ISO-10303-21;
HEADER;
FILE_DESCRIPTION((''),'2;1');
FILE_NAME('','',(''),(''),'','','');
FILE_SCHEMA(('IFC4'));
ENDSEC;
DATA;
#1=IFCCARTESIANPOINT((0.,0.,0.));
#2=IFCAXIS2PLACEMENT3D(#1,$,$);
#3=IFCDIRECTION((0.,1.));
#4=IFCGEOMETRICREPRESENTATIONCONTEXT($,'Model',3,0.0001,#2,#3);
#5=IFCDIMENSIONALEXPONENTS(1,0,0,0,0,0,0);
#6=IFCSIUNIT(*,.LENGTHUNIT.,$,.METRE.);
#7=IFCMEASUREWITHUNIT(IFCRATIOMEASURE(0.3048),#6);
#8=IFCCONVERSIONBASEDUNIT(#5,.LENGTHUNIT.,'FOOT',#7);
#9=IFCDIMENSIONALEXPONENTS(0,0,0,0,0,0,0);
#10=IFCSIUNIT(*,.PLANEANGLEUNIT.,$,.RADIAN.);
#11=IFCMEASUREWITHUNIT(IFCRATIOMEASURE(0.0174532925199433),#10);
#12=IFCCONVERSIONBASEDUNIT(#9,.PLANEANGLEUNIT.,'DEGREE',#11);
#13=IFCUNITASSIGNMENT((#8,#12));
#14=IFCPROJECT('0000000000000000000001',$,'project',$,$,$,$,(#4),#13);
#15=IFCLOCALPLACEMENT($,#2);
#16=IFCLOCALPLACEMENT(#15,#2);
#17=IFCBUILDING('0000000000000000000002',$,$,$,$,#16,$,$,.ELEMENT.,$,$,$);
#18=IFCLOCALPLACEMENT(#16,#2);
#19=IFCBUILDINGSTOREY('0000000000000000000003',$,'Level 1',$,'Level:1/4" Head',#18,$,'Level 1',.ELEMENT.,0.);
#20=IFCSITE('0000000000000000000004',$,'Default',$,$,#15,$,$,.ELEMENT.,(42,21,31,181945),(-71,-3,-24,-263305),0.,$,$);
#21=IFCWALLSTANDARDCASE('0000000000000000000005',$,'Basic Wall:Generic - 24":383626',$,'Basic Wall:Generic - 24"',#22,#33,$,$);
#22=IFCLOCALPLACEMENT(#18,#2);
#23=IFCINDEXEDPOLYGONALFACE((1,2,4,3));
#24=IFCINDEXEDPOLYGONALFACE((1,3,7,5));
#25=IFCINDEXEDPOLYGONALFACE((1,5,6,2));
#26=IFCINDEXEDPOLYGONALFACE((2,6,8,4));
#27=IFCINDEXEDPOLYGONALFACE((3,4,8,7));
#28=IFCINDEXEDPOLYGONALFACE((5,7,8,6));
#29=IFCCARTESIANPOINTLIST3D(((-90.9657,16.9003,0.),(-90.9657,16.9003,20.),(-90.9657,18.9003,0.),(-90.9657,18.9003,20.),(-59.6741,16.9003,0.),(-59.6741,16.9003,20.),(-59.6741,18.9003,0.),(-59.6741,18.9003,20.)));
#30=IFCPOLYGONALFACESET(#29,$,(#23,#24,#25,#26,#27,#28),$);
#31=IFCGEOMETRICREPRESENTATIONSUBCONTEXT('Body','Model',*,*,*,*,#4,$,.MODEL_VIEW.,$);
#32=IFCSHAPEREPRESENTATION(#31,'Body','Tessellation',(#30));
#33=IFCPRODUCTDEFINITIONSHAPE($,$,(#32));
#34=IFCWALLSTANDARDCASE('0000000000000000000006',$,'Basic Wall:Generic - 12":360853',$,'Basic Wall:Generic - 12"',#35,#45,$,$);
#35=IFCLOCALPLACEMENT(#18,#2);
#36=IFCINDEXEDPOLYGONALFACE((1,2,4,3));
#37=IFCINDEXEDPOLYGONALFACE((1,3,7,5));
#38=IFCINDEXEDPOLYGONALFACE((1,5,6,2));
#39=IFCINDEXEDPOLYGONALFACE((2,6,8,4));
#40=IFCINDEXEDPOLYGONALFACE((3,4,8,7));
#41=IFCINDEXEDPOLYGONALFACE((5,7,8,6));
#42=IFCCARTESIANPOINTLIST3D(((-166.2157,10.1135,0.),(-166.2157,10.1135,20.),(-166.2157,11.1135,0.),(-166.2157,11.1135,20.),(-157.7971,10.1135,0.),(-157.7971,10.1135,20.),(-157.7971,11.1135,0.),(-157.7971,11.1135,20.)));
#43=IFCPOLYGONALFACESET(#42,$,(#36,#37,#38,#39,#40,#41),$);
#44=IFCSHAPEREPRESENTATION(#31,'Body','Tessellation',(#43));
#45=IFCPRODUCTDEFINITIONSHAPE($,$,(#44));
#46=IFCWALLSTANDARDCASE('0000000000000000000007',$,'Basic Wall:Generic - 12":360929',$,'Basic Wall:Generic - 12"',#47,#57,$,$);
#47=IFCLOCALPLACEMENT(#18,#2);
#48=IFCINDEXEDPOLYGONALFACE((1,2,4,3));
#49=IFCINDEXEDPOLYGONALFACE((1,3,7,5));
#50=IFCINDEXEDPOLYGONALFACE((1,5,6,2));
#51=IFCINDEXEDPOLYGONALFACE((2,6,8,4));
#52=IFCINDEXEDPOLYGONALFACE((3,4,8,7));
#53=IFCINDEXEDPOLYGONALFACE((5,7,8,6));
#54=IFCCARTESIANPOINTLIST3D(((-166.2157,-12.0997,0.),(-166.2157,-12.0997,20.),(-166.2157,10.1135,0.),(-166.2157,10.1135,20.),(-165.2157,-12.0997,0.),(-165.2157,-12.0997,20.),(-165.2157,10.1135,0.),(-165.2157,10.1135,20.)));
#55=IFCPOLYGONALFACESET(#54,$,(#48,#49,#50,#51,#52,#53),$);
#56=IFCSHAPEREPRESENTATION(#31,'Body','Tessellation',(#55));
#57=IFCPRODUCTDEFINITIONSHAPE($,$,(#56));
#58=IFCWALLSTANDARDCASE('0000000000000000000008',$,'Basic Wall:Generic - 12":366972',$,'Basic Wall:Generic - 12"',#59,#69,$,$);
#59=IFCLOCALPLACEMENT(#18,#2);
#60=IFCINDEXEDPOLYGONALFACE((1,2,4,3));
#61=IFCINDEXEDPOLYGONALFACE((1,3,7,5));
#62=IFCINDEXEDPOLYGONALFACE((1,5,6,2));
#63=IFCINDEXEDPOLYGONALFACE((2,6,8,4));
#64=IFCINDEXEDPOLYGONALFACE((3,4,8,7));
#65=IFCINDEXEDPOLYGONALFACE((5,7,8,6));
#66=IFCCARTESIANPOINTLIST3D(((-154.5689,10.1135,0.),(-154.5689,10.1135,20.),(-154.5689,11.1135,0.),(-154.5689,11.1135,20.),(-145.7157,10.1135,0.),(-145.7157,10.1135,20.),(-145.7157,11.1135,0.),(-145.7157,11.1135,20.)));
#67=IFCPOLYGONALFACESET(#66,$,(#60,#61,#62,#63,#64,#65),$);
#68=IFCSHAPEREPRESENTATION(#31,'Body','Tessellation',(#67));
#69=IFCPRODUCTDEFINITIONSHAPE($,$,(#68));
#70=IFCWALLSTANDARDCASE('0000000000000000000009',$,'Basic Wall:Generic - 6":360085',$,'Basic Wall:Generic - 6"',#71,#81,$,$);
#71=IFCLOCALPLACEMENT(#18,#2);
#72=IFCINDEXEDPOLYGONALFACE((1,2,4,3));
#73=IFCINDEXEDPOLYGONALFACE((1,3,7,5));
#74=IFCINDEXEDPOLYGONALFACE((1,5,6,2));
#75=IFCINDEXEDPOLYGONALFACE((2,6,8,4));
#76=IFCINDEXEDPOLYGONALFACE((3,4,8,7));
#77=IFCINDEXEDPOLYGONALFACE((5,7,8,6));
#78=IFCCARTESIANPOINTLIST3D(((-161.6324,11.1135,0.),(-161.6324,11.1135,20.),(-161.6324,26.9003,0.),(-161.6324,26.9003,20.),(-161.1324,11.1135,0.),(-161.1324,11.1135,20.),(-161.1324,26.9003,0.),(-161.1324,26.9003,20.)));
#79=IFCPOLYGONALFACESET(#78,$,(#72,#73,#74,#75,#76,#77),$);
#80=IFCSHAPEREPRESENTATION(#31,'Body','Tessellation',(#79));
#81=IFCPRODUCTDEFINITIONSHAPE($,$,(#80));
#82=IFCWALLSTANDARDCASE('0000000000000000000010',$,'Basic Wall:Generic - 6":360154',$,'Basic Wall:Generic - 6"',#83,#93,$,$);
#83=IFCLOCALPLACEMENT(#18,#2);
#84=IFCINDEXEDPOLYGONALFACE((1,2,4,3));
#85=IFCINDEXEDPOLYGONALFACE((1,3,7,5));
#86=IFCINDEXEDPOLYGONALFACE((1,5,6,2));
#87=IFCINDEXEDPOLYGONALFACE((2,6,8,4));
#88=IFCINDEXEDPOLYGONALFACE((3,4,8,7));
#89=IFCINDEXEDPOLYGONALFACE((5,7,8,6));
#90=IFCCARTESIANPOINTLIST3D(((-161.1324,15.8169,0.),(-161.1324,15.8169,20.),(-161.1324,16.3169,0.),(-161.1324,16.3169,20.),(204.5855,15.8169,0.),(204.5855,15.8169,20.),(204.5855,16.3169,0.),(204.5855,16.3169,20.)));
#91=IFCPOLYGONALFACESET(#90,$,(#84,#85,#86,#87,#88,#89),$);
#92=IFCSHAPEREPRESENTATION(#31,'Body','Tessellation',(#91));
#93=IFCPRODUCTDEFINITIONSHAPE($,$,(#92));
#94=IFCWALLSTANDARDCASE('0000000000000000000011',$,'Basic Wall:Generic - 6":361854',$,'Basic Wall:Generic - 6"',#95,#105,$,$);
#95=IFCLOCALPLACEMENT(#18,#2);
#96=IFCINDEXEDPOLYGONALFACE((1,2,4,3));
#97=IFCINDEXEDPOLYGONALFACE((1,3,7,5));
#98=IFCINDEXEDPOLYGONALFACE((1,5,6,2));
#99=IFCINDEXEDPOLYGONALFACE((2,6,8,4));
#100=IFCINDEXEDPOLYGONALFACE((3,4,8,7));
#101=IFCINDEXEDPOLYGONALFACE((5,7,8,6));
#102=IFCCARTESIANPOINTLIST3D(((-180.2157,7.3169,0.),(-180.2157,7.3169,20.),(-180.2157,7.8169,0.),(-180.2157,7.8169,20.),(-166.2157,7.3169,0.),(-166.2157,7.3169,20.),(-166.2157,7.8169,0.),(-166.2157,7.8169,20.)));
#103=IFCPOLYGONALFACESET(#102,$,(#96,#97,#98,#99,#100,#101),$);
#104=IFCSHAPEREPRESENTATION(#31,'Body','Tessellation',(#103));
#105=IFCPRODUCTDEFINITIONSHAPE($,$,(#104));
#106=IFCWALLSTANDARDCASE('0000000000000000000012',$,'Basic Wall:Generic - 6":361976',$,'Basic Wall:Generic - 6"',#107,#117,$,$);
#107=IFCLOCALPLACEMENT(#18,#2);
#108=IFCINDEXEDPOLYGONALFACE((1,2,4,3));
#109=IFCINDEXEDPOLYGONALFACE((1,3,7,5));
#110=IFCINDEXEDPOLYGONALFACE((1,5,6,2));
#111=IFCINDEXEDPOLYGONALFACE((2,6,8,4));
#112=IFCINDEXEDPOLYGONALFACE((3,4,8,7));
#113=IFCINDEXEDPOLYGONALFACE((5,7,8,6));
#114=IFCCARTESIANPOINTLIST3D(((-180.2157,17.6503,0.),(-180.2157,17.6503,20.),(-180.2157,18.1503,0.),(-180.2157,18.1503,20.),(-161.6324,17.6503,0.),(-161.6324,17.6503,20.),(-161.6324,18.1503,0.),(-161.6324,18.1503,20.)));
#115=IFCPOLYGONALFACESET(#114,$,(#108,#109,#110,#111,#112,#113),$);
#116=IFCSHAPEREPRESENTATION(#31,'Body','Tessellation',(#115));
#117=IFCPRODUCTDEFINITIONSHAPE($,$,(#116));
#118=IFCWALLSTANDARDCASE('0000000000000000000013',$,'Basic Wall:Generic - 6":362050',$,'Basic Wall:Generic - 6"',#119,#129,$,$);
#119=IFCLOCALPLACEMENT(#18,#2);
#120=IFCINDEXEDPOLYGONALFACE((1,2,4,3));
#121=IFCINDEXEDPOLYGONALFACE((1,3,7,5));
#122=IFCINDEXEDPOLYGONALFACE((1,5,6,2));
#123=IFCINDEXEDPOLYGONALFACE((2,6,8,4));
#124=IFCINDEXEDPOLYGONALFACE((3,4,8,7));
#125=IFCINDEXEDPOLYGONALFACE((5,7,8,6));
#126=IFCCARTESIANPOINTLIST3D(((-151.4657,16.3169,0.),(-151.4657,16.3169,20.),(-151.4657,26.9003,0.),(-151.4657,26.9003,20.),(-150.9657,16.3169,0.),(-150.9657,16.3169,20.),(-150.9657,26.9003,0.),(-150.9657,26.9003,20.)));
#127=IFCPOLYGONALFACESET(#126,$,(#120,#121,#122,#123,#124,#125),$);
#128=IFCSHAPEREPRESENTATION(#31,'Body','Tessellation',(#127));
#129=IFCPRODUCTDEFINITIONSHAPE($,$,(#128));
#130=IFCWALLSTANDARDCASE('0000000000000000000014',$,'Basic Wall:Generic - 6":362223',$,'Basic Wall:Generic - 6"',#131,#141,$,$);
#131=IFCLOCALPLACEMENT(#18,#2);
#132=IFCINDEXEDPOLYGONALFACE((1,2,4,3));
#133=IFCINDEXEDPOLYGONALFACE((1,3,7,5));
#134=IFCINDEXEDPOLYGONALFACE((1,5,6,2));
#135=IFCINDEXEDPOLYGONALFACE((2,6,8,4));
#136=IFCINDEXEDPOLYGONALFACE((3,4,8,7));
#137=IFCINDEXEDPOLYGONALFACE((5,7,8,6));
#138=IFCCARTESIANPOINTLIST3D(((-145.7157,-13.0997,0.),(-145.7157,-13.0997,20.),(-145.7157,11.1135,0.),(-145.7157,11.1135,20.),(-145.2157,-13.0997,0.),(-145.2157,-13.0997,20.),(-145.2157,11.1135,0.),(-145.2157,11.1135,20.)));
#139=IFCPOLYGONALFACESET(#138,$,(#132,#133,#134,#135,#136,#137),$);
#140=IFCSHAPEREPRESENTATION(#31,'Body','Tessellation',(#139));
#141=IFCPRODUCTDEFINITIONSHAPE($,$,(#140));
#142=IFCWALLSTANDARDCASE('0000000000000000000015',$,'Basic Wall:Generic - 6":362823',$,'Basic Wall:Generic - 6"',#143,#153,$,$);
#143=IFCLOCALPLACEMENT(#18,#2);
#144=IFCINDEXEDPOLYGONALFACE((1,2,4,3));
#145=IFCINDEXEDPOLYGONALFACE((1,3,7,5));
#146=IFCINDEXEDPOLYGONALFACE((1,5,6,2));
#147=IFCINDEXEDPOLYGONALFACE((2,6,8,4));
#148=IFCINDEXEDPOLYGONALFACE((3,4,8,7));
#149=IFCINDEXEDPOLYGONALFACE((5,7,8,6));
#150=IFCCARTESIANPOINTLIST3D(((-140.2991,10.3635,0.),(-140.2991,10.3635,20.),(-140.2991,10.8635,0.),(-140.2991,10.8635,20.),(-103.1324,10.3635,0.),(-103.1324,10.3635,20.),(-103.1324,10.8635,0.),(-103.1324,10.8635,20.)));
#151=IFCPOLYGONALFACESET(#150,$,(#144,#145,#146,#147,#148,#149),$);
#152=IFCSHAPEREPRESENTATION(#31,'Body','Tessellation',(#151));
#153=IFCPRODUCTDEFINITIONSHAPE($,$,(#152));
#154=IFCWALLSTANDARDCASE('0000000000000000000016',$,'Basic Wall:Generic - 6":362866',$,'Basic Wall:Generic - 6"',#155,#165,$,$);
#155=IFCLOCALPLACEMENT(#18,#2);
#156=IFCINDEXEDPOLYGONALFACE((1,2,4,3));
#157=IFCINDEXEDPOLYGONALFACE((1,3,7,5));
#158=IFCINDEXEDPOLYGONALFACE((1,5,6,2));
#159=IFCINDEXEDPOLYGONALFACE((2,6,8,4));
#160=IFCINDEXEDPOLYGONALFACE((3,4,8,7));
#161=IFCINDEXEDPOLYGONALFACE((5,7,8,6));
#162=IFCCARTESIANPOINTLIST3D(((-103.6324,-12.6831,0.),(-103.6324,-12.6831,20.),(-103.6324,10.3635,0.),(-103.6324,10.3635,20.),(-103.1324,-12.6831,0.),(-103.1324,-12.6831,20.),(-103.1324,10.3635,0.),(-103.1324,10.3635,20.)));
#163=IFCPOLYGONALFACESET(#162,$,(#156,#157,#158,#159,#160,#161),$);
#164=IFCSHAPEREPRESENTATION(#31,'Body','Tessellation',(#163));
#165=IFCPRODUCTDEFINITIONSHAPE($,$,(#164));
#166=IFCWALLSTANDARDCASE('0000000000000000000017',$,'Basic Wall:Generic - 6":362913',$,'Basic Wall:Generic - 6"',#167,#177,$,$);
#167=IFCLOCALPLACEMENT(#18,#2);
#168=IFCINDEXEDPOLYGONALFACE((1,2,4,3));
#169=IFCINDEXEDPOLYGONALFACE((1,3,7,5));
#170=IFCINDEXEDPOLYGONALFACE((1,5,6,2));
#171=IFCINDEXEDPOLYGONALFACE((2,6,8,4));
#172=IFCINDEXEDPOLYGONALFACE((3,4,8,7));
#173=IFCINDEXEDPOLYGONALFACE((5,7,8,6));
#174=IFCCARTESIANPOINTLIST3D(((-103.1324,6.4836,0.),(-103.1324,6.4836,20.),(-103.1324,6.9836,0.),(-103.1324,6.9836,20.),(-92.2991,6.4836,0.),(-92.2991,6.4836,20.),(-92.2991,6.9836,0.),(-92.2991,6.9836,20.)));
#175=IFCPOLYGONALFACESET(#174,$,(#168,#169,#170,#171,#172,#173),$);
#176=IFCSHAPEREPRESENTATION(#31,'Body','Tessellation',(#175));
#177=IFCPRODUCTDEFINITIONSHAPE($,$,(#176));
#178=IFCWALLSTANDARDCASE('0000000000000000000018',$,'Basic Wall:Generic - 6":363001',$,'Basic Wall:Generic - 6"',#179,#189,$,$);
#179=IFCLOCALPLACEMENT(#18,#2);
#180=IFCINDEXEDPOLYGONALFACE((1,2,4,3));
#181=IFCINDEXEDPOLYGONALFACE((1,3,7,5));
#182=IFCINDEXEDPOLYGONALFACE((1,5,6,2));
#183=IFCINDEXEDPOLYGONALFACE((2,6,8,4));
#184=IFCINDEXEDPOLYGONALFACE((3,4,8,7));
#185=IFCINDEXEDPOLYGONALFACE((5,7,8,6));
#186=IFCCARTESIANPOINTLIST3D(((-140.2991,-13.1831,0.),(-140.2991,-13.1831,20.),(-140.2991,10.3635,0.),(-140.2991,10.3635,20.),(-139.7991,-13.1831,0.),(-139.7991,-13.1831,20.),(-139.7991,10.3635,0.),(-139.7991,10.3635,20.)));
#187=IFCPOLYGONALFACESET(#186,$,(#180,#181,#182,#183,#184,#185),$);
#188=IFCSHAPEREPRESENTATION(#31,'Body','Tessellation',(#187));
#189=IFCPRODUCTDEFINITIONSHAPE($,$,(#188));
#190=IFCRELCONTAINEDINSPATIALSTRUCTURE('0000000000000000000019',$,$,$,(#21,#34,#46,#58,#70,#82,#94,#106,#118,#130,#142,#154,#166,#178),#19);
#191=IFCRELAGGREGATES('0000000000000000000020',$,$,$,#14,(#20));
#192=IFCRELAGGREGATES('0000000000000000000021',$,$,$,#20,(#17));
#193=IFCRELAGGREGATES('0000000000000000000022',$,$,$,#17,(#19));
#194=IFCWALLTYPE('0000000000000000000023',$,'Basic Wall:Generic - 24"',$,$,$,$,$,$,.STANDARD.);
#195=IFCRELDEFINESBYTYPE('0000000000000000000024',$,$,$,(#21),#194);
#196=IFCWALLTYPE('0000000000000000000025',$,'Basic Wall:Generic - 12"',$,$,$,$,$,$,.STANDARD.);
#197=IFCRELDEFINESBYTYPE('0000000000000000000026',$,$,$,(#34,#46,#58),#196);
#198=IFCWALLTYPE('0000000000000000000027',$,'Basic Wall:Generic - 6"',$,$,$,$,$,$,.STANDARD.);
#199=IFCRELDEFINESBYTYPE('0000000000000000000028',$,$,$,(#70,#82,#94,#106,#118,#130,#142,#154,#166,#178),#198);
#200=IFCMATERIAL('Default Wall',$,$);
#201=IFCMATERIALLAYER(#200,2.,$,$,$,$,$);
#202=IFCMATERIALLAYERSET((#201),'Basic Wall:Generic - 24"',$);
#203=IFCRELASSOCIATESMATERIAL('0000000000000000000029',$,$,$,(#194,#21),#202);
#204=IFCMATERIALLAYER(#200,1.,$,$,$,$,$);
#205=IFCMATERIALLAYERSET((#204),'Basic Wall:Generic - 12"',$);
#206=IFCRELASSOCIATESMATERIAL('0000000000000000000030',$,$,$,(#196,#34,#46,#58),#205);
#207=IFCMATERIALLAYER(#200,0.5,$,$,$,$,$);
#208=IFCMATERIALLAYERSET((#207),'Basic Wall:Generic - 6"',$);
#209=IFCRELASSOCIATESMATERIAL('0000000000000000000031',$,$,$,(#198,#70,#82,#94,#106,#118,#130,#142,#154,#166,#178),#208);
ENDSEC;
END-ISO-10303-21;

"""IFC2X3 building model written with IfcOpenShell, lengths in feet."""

from ifc_helpers import new_model, entity, si_unit, converted_unit, direction, frame, frame_2d, origin, place, context, subcontext, project, spatial, rectangle, extrude, material, layer, layer_set, layer_usage, type_object, element, save


model = new_model("IFC2X3")

# Units and contexts
model_context = context("Model", 3, precision=0.0001, world=origin(), true_north=direction((0.0, 1.0)))
body_context = subcontext(model_context, "Body", "Model", "MODEL_VIEW")
ifc_project = project(units=[converted_unit("LENGTHUNIT", "FOOT", entity("IfcRatioMeasure", 0.3048), si_unit("LENGTHUNIT", "METRE"), dimensions=[1, 0, 0, 0, 0, 0, 0]), converted_unit("PLANEANGLEUNIT", "DEGREE", entity("IfcRatioMeasure", 0.0174532925199433), si_unit("PLANEANGLEUNIT", "RADIAN"), dimensions=[0, 0, 0, 0, 0, 0, 0])], contexts=[model_context])

# Site, building, storey
site_placement = place(None, origin())
site = spatial("IfcSite", under=ifc_project, at=site_placement, Name="Default", CompositionType="ELEMENT", RefLatitude=(42, 21, 31, 181945), RefLongitude=(-71, -3, -24, -263305), RefElevation=0.0)
building_placement = place(site_placement, origin())
building = spatial("IfcBuilding", under=site, at=building_placement, CompositionType="ELEMENT")
storey_placement = place(building_placement, origin())
storey = spatial("IfcBuildingStorey", under=building, at=storey_placement, Name="Level 1", ObjectType="Level:1/4\" Head", LongName="Level 1", CompositionType="ELEMENT", Elevation=0.0)

# Walls
ifc_material = material(Name="Default Wall")
ifc_layer_1 = layer(ifc_material, 2.0)
ifc_layer_set_1 = layer_set([ifc_layer_1], Name="Basic Wall:Generic - 24\"")
ifc_layer_usage_1 = layer_usage(ifc_layer_set_1, "AXIS2", "NEGATIVE", 1.0)
wall_type_1 = type_object("IfcWallType", Name="Basic Wall:Generic - 24\"", PredefinedType="STANDARD", material=ifc_layer_set_1)
wall_1_placement = place(storey_placement, frame((-90.9657, 17.9003, 0.0)))
element("IfcWallStandardCase", 1, at=wall_1_placement, inside=storey, type_object=wall_type_1, material=ifc_layer_usage_1, Name="Basic Wall:Generic - 24\":383626", ObjectType="Basic Wall:Generic - 24\"", context=body_context, shape_type="SweptSolid", body=[
    extrude(rectangle(XDim=31.2917, YDim=2.0, at=frame_2d((15.6458, 0.0), x_axis=(-1.0, 0.0))), origin(), (0.0, 0.0, 1.0), 20.0),
])
ifc_layer_2 = layer(ifc_material, 1.0)
ifc_layer_set_2 = layer_set([ifc_layer_2], Name="Basic Wall:Generic - 12\"")
ifc_layer_usage_2 = layer_usage(ifc_layer_set_2, "AXIS2", "NEGATIVE", 0.5)
wall_type_2 = type_object("IfcWallType", Name="Basic Wall:Generic - 12\"", PredefinedType="STANDARD", material=ifc_layer_set_2)
wall_2_placement = place(storey_placement, frame((-157.7971, 10.6135, 0.0), z_axis=(0.0, 0.0, 1.0), x_axis=(-1.0, 0.0, 0.0)))
element("IfcWallStandardCase", 2, at=wall_2_placement, inside=storey, type_object=wall_type_2, material=ifc_layer_usage_2, Name="Basic Wall:Generic - 12\":360853", ObjectType="Basic Wall:Generic - 12\"", context=body_context, shape_type="SweptSolid", body=[
    extrude(rectangle(XDim=8.4186, YDim=1.0, at=frame_2d((4.2093, 0.0), x_axis=(-1.0, 0.0))), origin(), (0.0, 0.0, 1.0), 20.0),
])
ifc_layer_usage_3 = layer_usage(ifc_layer_set_2, "AXIS2", "NEGATIVE", 0.5)
wall_3_placement = place(storey_placement, frame((-165.7157, 10.1135, 0.0), z_axis=(0.0, 0.0, 1.0), x_axis=(0.0, -1.0, 0.0)))
element("IfcWallStandardCase", 3, at=wall_3_placement, inside=storey, type_object=wall_type_2, material=ifc_layer_usage_3, Name="Basic Wall:Generic - 12\":360929", ObjectType="Basic Wall:Generic - 12\"", context=body_context, shape_type="SweptSolid", body=[
    extrude(rectangle(XDim=22.2133, YDim=1.0, at=frame_2d((11.1066, 0.0), x_axis=(-1.0, 0.0))), origin(), (0.0, 0.0, 1.0), 20.0),
])
ifc_layer_usage_4 = layer_usage(ifc_layer_set_2, "AXIS2", "NEGATIVE", 0.5)
wall_4_placement = place(storey_placement, frame((-154.5689, 10.6135, 0.0)))
element("IfcWallStandardCase", 4, at=wall_4_placement, inside=storey, type_object=wall_type_2, material=ifc_layer_usage_4, Name="Basic Wall:Generic - 12\":366972", ObjectType="Basic Wall:Generic - 12\"", context=body_context, shape_type="SweptSolid", body=[
    extrude(rectangle(XDim=8.8532, YDim=1.0, at=frame_2d((4.4266, 0.0), x_axis=(-1.0, 0.0))), origin(), (0.0, 0.0, 1.0), 20.0),
])
ifc_layer_3 = layer(ifc_material, 0.5)
ifc_layer_set_3 = layer_set([ifc_layer_3], Name="Basic Wall:Generic - 6\"")
ifc_layer_usage_5 = layer_usage(ifc_layer_set_3, "AXIS2", "NEGATIVE", 0.25)
wall_type_3 = type_object("IfcWallType", Name="Basic Wall:Generic - 6\"", PredefinedType="STANDARD", material=ifc_layer_set_3)
wall_5_placement = place(storey_placement, frame((-161.3824, 26.9003, 0.0), z_axis=(0.0, 0.0, 1.0), x_axis=(0.0, -1.0, 0.0)))
element("IfcWallStandardCase", 5, at=wall_5_placement, inside=storey, type_object=wall_type_3, material=ifc_layer_usage_5, Name="Basic Wall:Generic - 6\":360085", ObjectType="Basic Wall:Generic - 6\"", context=body_context, shape_type="SweptSolid", body=[
    extrude(rectangle(XDim=15.7867, YDim=0.5, at=frame_2d((7.8934, 0.0), x_axis=(-1.0, 0.0))), origin(), (0.0, 0.0, 1.0), 20.0),
])
ifc_layer_usage_6 = layer_usage(ifc_layer_set_3, "AXIS2", "NEGATIVE", 0.25)
wall_6_placement = place(storey_placement, frame((-161.1324, 16.0669, 0.0)))
element("IfcWallStandardCase", 6, at=wall_6_placement, inside=storey, type_object=wall_type_3, material=ifc_layer_usage_6, Name="Basic Wall:Generic - 6\":360154", ObjectType="Basic Wall:Generic - 6\"", context=body_context, shape_type="SweptSolid", body=[
    extrude(rectangle(XDim=365.7179, YDim=0.5, at=frame_2d((182.859, 0.0), x_axis=(-1.0, 0.0))), origin(), (0.0, 0.0, 1.0), 20.0),
])
ifc_layer_usage_7 = layer_usage(ifc_layer_set_3, "AXIS2", "NEGATIVE", 0.25)
wall_7_placement = place(storey_placement, frame((-180.2157, 7.5669, 0.0)))
element("IfcWallStandardCase", 7, at=wall_7_placement, inside=storey, type_object=wall_type_3, material=ifc_layer_usage_7, Name="Basic Wall:Generic - 6\":361854", ObjectType="Basic Wall:Generic - 6\"", context=body_context, shape_type="SweptSolid", body=[
    extrude(rectangle(XDim=14.0, YDim=0.5, at=frame_2d((7.0, 0.0), x_axis=(-1.0, 0.0))), origin(), (0.0, 0.0, 1.0), 20.0),
])
ifc_layer_usage_8 = layer_usage(ifc_layer_set_3, "AXIS2", "NEGATIVE", 0.25)
wall_8_placement = place(storey_placement, frame((-180.2157, 17.9003, 0.0)))
element("IfcWallStandardCase", 8, at=wall_8_placement, inside=storey, type_object=wall_type_3, material=ifc_layer_usage_8, Name="Basic Wall:Generic - 6\":361976", ObjectType="Basic Wall:Generic - 6\"", context=body_context, shape_type="SweptSolid", body=[
    extrude(rectangle(XDim=18.5833, YDim=0.5, at=frame_2d((9.2917, 0.0), x_axis=(-1.0, 0.0))), origin(), (0.0, 0.0, 1.0), 20.0),
])
ifc_layer_usage_9 = layer_usage(ifc_layer_set_3, "AXIS2", "NEGATIVE", 0.25)
wall_9_placement = place(storey_placement, frame((-151.2157, 26.9003, 0.0), z_axis=(0.0, 0.0, 1.0), x_axis=(0.0, -1.0, 0.0)))
element("IfcWallStandardCase", 9, at=wall_9_placement, inside=storey, type_object=wall_type_3, material=ifc_layer_usage_9, Name="Basic Wall:Generic - 6\":362050", ObjectType="Basic Wall:Generic - 6\"", context=body_context, shape_type="SweptSolid", body=[
    extrude(rectangle(XDim=10.5833, YDim=0.5, at=frame_2d((5.2917, 0.0), x_axis=(-1.0, 0.0))), origin(), (0.0, 0.0, 1.0), 20.0),
])
ifc_layer_usage_10 = layer_usage(ifc_layer_set_3, "AXIS2", "NEGATIVE", 0.25)
wall_10_placement = place(storey_placement, frame((-145.4657, 11.1135, 0.0), z_axis=(0.0, 0.0, 1.0), x_axis=(0.0, -1.0, 0.0)))
element("IfcWallStandardCase", 10, at=wall_10_placement, inside=storey, type_object=wall_type_3, material=ifc_layer_usage_10, Name="Basic Wall:Generic - 6\":362223", ObjectType="Basic Wall:Generic - 6\"", context=body_context, shape_type="SweptSolid", body=[
    extrude(rectangle(XDim=24.2133, YDim=0.5, at=frame_2d((12.1066, 0.0), x_axis=(-1.0, 0.0))), origin(), (0.0, 0.0, 1.0), 20.0),
])
ifc_layer_usage_11 = layer_usage(ifc_layer_set_3, "AXIS2", "NEGATIVE", 0.25)
wall_11_placement = place(storey_placement, frame((-140.2991, 10.6135, 0.0)))
element("IfcWallStandardCase", 11, at=wall_11_placement, inside=storey, type_object=wall_type_3, material=ifc_layer_usage_11, Name="Basic Wall:Generic - 6\":362823", ObjectType="Basic Wall:Generic - 6\"", context=body_context, shape_type="SweptSolid", body=[
    extrude(rectangle(XDim=37.1667, YDim=0.5, at=frame_2d((18.5833, 0.0), x_axis=(-1.0, 0.0))), origin(), (0.0, 0.0, 1.0), 20.0),
])
ifc_layer_usage_12 = layer_usage(ifc_layer_set_3, "AXIS2", "POSITIVE", -0.25)
wall_12_placement = place(storey_placement, frame((-103.3824, 10.3635, 0.0), z_axis=(0.0, 0.0, 1.0), x_axis=(0.0, -1.0, 0.0)))
element("IfcWallStandardCase", 12, at=wall_12_placement, inside=storey, type_object=wall_type_3, material=ifc_layer_usage_12, Name="Basic Wall:Generic - 6\":362866", ObjectType="Basic Wall:Generic - 6\"", context=body_context, shape_type="SweptSolid", body=[
    extrude(rectangle(XDim=23.0466, YDim=0.5, at=frame_2d((11.5233, 0.0), x_axis=(-1.0, 0.0))), origin(), (0.0, 0.0, 1.0), 20.0),
])
ifc_layer_usage_13 = layer_usage(ifc_layer_set_3, "AXIS2", "NEGATIVE", 0.25)
wall_13_placement = place(storey_placement, frame((-103.1324, 6.7336, 0.0)))
element("IfcWallStandardCase", 13, at=wall_13_placement, inside=storey, type_object=wall_type_3, material=ifc_layer_usage_13, Name="Basic Wall:Generic - 6\":362913", ObjectType="Basic Wall:Generic - 6\"", context=body_context, shape_type="SweptSolid", body=[
    extrude(rectangle(XDim=10.8333, YDim=0.5, at=frame_2d((5.4167, 0.0), x_axis=(-1.0, 0.0))), origin(), (0.0, 0.0, 1.0), 20.0),
])
ifc_layer_usage_14 = layer_usage(ifc_layer_set_3, "AXIS2", "NEGATIVE", 0.25)
wall_14_placement = place(storey_placement, frame((-140.0491, 10.3635, 0.0), z_axis=(0.0, 0.0, 1.0), x_axis=(0.0, -1.0, 0.0)))
element("IfcWallStandardCase", 14, at=wall_14_placement, inside=storey, type_object=wall_type_3, material=ifc_layer_usage_14, Name="Basic Wall:Generic - 6\":363001", ObjectType="Basic Wall:Generic - 6\"", context=body_context, shape_type="SweptSolid", body=[
    extrude(rectangle(XDim=23.5466, YDim=0.5, at=frame_2d((11.7733, 0.0), x_axis=(-1.0, 0.0))), origin(), (0.0, 0.0, 1.0), 20.0),
])

save(model, "model.ifc")
